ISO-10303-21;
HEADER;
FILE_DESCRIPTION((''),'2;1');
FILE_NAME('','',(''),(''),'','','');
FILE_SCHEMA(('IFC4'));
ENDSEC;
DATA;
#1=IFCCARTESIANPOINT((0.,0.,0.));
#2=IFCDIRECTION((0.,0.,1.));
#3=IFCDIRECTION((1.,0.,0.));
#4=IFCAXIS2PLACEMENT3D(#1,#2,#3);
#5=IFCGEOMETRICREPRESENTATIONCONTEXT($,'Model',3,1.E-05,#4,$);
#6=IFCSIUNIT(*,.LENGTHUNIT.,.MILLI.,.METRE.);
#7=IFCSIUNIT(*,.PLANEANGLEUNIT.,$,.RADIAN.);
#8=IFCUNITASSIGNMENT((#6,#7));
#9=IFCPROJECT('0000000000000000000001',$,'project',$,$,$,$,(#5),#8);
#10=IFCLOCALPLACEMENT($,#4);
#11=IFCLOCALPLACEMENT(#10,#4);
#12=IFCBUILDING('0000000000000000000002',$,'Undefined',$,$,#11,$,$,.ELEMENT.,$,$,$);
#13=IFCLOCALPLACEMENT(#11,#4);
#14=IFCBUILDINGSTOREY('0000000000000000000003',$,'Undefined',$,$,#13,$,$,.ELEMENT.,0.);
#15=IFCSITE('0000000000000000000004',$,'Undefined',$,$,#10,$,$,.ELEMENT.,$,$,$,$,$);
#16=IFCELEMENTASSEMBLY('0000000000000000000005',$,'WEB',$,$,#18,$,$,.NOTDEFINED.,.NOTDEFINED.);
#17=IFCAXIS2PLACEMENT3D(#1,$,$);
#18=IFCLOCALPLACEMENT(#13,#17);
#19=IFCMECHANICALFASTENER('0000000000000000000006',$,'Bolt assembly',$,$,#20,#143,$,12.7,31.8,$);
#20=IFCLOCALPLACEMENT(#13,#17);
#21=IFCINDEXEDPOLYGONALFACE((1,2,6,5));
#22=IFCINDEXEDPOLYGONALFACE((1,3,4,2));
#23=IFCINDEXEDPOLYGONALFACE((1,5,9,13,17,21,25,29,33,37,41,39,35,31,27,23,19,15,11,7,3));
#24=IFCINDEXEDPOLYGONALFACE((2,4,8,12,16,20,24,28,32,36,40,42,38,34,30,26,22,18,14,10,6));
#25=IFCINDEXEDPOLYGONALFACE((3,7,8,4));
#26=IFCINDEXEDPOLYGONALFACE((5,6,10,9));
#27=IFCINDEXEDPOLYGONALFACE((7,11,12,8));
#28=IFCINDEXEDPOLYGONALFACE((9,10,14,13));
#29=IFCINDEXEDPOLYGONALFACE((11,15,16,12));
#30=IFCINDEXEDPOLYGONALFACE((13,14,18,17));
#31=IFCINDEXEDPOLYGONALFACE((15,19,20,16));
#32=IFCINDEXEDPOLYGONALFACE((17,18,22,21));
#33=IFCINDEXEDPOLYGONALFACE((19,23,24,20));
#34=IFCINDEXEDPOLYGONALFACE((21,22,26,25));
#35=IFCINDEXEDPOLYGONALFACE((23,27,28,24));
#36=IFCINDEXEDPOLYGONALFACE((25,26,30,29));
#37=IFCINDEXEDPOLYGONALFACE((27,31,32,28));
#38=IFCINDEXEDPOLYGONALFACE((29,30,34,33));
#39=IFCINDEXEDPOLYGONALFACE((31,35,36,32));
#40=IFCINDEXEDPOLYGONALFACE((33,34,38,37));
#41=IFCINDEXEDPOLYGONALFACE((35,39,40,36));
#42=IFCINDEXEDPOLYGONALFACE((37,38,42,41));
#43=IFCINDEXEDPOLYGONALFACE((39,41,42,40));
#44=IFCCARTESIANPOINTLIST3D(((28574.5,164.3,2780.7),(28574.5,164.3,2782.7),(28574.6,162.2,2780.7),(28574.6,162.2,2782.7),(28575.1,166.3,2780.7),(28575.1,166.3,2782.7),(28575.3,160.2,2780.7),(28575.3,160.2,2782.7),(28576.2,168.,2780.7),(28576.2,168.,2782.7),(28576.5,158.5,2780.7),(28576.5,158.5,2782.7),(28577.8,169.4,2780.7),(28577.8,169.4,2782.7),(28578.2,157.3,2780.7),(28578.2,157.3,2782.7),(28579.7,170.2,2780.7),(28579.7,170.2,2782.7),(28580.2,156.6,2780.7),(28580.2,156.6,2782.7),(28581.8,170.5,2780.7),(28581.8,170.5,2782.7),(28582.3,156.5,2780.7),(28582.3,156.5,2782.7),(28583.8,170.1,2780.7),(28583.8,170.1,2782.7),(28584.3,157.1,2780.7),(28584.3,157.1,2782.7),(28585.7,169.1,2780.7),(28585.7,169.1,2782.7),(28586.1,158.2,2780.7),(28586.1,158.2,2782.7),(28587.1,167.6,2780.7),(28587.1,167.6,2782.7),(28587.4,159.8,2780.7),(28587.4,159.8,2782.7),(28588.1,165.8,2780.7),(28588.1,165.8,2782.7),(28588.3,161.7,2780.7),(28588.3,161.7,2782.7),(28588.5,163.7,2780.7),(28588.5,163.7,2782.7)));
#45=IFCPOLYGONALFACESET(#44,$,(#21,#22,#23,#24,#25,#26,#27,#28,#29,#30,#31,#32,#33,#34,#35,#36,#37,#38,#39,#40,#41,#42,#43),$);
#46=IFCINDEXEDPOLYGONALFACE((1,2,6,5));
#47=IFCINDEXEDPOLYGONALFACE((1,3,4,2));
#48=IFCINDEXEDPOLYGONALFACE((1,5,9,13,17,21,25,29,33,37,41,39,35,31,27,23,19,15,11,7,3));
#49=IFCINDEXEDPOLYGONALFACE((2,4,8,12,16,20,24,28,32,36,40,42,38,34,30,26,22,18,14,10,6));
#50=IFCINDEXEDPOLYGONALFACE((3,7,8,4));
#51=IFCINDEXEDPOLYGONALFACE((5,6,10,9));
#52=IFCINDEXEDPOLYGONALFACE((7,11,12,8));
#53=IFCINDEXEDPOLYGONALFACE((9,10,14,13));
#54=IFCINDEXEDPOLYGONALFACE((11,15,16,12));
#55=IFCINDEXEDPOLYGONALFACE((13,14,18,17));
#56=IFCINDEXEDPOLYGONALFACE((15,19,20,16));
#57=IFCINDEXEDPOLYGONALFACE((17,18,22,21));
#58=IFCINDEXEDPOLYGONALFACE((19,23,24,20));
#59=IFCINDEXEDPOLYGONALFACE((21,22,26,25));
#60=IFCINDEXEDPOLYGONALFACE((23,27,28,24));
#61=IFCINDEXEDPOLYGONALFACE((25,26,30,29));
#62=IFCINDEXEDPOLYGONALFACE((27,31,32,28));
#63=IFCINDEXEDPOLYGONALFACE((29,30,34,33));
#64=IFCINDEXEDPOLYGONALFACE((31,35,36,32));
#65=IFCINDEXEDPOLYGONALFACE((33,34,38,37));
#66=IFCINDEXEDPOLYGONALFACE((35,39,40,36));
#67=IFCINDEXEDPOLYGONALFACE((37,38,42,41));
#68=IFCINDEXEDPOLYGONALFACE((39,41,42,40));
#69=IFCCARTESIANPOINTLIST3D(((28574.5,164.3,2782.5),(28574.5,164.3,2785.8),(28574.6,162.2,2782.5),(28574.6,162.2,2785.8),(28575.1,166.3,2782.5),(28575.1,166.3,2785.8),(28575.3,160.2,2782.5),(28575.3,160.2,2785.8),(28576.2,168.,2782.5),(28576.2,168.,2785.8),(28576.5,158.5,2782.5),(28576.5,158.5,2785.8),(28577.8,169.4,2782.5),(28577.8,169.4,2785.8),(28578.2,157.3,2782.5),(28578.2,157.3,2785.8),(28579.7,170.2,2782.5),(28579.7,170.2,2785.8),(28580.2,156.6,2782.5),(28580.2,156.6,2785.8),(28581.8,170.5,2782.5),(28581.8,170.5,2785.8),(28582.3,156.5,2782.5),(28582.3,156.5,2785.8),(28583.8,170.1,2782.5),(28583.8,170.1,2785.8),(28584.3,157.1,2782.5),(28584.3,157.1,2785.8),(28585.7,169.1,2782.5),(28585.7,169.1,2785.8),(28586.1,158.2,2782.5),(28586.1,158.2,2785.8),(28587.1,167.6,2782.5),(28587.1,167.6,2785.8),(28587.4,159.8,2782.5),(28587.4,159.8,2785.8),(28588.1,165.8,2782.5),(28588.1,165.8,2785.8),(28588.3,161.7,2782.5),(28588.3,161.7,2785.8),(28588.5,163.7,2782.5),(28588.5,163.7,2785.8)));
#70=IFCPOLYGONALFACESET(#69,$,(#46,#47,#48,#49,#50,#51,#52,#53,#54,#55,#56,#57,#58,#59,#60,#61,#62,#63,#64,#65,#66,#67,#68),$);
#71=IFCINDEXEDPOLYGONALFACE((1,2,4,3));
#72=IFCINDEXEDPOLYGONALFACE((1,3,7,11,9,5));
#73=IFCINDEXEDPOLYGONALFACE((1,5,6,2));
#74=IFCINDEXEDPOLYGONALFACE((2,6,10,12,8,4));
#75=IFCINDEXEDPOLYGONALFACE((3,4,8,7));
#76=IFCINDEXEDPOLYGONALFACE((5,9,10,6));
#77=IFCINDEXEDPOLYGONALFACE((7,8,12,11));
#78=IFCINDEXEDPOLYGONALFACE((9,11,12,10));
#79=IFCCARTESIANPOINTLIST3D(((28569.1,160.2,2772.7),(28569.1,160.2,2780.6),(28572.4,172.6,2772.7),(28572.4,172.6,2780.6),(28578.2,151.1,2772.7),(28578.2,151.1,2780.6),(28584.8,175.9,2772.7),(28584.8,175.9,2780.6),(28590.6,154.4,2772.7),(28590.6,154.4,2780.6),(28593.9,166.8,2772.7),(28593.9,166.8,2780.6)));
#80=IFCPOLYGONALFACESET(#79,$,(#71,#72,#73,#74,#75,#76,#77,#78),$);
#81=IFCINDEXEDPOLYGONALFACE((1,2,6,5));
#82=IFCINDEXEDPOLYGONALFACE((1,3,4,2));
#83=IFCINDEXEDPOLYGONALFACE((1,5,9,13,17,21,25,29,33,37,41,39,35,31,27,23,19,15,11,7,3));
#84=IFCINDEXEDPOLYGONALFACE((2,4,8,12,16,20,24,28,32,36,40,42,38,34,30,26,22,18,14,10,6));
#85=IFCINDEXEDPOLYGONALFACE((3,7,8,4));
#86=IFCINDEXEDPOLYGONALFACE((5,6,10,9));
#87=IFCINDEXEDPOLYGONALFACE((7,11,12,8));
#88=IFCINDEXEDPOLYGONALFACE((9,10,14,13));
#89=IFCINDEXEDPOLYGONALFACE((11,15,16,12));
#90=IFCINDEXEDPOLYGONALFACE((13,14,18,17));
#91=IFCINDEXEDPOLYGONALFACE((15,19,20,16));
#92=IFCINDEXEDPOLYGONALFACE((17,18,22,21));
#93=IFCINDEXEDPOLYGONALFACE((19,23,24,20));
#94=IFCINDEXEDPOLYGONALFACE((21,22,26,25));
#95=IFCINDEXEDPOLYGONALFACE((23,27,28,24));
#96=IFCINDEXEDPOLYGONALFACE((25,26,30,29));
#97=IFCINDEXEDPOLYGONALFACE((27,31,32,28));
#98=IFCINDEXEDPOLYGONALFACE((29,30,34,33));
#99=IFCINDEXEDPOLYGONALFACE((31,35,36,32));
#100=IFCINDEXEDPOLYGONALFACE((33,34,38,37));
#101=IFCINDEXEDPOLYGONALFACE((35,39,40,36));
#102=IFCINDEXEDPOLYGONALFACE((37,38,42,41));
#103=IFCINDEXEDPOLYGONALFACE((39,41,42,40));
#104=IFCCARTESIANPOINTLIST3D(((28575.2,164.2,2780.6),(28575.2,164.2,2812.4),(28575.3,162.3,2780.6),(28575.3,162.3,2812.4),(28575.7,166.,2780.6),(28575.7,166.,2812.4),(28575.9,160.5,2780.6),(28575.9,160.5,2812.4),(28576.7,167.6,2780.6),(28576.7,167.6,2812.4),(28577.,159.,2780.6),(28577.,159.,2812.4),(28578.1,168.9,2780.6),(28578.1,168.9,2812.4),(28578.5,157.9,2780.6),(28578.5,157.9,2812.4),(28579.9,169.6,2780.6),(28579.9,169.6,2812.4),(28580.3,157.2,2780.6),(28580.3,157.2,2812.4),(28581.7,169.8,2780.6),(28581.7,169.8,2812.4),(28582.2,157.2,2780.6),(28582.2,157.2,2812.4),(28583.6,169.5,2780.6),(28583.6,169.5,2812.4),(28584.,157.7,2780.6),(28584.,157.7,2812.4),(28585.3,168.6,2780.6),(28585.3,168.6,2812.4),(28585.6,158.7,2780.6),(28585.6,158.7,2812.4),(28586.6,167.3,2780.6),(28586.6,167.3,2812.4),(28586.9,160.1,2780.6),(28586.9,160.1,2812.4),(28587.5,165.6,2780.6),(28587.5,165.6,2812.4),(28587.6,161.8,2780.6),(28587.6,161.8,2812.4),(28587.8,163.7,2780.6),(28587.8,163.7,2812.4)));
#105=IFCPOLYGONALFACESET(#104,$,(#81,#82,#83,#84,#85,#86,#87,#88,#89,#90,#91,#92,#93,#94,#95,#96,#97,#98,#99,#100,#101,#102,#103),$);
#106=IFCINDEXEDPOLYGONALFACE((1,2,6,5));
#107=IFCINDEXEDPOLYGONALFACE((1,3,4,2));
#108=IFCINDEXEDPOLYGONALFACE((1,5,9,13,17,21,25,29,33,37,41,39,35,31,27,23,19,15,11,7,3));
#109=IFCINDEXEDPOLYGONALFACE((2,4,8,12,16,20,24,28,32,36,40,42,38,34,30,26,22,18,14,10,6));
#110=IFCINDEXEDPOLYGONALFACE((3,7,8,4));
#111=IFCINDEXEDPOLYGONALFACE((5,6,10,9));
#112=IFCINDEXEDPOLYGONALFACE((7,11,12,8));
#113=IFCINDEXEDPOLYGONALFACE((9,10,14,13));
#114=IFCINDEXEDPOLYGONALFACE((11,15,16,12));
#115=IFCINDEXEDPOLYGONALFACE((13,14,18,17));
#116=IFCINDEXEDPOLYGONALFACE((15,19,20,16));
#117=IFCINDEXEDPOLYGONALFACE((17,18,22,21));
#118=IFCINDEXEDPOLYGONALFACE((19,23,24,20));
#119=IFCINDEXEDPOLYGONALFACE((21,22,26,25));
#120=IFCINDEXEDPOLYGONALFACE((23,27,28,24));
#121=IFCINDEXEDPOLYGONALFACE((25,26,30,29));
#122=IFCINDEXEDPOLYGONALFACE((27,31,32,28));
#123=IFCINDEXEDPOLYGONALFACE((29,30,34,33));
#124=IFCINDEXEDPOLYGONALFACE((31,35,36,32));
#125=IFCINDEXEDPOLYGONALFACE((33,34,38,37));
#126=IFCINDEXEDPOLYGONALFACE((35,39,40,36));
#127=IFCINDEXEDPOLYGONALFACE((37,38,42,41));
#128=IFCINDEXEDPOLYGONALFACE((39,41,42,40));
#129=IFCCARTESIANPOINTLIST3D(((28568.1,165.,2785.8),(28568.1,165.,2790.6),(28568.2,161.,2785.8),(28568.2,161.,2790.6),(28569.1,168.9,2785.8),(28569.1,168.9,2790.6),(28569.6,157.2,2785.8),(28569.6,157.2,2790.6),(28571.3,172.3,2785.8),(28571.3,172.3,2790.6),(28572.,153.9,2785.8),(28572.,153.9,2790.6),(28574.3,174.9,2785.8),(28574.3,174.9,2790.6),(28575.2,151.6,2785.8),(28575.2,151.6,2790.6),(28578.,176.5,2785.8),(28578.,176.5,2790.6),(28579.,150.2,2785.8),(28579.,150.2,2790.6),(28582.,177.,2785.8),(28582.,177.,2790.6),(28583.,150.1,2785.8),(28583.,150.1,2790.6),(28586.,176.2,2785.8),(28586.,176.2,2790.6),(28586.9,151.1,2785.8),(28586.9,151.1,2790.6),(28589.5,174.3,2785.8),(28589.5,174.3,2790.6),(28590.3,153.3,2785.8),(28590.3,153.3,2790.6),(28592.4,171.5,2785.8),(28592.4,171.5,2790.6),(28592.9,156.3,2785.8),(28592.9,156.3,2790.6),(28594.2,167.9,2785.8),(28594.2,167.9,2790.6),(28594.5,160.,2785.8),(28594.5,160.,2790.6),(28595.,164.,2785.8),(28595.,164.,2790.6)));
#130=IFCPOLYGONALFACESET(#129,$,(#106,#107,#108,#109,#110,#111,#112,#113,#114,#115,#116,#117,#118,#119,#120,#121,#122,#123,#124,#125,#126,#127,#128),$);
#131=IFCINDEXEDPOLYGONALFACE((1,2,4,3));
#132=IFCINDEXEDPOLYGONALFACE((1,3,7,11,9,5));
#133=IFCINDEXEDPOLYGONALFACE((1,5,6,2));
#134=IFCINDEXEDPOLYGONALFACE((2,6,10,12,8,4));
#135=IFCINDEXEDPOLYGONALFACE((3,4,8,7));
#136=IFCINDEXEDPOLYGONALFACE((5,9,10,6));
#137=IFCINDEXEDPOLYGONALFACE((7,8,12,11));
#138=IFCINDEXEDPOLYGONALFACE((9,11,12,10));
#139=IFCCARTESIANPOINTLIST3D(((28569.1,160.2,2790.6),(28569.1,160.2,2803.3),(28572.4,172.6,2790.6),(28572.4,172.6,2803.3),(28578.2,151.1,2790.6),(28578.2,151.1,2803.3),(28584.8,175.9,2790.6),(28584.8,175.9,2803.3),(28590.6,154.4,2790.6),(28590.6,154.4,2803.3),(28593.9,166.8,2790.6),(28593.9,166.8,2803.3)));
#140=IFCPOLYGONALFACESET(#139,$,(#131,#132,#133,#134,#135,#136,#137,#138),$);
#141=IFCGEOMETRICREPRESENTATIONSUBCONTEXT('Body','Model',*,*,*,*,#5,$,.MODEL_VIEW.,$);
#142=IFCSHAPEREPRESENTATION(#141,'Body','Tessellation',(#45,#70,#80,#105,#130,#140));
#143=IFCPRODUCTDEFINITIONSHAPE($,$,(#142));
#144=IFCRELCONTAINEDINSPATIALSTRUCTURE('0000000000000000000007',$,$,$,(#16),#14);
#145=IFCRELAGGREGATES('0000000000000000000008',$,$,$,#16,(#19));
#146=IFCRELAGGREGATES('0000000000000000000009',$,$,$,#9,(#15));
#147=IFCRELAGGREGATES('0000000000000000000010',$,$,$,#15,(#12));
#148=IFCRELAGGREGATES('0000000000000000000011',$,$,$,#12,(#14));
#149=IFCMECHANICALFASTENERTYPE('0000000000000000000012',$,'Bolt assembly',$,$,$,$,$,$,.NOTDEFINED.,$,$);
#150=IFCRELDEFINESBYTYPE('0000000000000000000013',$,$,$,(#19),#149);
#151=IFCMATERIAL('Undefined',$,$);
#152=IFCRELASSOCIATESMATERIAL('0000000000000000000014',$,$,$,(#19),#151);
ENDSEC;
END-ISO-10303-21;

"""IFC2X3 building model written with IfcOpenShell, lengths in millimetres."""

from ifc_helpers import new_model, si_unit, frame, origin_with_axes, origin_2d_with_axis, place, context, subcontext, project, spatial, polyline, circle, outline, extrude, source, transform, mapped, material, type_object, element, aggregate, save


model = new_model("IFC2X3")

# Units and contexts
model_context = context("Model", 3, precision=1e-05, world=origin_with_axes())
body_context = subcontext(model_context, "Body", "Model", "MODEL_VIEW")
ifc_project = project(units=[si_unit("LENGTHUNIT", "METRE", prefix="MILLI"), si_unit("PLANEANGLEUNIT", "RADIAN")], contexts=[model_context])

# Site, building, storey
site_placement = place(None, origin_with_axes())
site = spatial("IfcSite", under=ifc_project, at=site_placement, Name="Undefined", CompositionType="ELEMENT")
building_placement = place(site_placement, origin_with_axes())
building = spatial("IfcBuilding", under=site, at=building_placement, Name="Undefined", CompositionType="ELEMENT")
storey_placement = place(building_placement, origin_with_axes())
storey = spatial("IfcBuildingStorey", under=building, at=storey_placement, Name="Undefined", CompositionType="ELEMENT", Elevation=0.0)

# Element assembly
assembly_1_placement = place(storey_placement, origin_with_axes())
assembly_1 = element("IfcElementAssembly", 1, at=assembly_1_placement, inside=storey, Name="WEB", AssemblyPlace="NOTDEFINED", PredefinedType="NOTDEFINED")

# Shared definitions
ifc_material_1 = material(Name="Undefined")
mechanical_fastener_type = type_object("IfcMechanicalFastenerType", Name="Bolt assembly")

# Mechanical fastener
shared_shape_1 = source(origin_with_axes(), body_context, "Body", "SweptSolid", [
    extrude(circle(Radius=7.0, at=origin_2d_with_axis()), frame((0.0, -1.9, 0.0), z_axis=(0.0, 1.0, 0.0), x_axis=(1.0, 0.0, 0.0)), (0.0, 0.0, 1.0), 2.0),
    extrude(circle(Radius=7.0, at=origin_2d_with_axis()), frame((0.0, -0.1, 0.0), z_axis=(0.0, 1.0, 0.0), x_axis=(1.0, 0.0, 0.0)), (0.0, 0.0, 1.0), 3.3),
    extrude(outline(polyline([(11.1, -6.4), (11.1, 6.4), (0.0, 12.8), (-11.1, 6.4), (-11.1, -6.4), (0.0, -12.8), (11.1, -6.4)])), frame((0.0, -9.9, 0.0), z_axis=(0.0, 1.0, 0.0), x_axis=(1.0, 0.0, 0.0)), (0.0, 0.0, 1.0), 7.9),
    extrude(circle(Radius=6.3, at=origin_2d_with_axis()), frame((0.0, -2.0, 0.0), z_axis=(0.0, 1.0, 0.0), x_axis=(1.0, 0.0, 0.0)), (0.0, 0.0, 1.0), 31.8),
    extrude(circle(Radius=13.5, at=origin_2d_with_axis()), frame((0.0, 3.2, 0.0), z_axis=(0.0, 1.0, 0.0), x_axis=(1.0, 0.0, 0.0)), (0.0, 0.0, 1.0), 4.8),
    extrude(outline(polyline([(11.1, -6.4), (11.1, 6.4), (0.0, 12.8), (-11.1, 6.4), (-11.1, -6.4), (0.0, -12.8), (11.1, -6.4)])), frame((0.0, 8.0, 0.0), z_axis=(0.0, 1.0, 0.0), x_axis=(1.0, 0.0, 0.0)), (0.0, 0.0, 1.0), 12.7),
])
mechanical_fastener_1_placement = place(assembly_1_placement, frame((28581.5, 163.5, 2782.6), z_axis=(-0.707107, 0.707107, -0.000005), x_axis=(-0.707106, -0.707107, 0.000005)))
mechanical_fastener_1 = element("IfcMechanicalFastener", 2, at=mechanical_fastener_1_placement, type_object=mechanical_fastener_type, material=ifc_material_1, Name="Bolt assembly", NominalDiameter=12.7, NominalLength=31.8, context=body_context, shape_type="MappedRepresentation", body=[
    mapped(shared_shape_1, transform((0.0, 0.0, 0.0))),
])

aggregate(assembly_1, [mechanical_fastener_1])

save(model, "model.ifc")
